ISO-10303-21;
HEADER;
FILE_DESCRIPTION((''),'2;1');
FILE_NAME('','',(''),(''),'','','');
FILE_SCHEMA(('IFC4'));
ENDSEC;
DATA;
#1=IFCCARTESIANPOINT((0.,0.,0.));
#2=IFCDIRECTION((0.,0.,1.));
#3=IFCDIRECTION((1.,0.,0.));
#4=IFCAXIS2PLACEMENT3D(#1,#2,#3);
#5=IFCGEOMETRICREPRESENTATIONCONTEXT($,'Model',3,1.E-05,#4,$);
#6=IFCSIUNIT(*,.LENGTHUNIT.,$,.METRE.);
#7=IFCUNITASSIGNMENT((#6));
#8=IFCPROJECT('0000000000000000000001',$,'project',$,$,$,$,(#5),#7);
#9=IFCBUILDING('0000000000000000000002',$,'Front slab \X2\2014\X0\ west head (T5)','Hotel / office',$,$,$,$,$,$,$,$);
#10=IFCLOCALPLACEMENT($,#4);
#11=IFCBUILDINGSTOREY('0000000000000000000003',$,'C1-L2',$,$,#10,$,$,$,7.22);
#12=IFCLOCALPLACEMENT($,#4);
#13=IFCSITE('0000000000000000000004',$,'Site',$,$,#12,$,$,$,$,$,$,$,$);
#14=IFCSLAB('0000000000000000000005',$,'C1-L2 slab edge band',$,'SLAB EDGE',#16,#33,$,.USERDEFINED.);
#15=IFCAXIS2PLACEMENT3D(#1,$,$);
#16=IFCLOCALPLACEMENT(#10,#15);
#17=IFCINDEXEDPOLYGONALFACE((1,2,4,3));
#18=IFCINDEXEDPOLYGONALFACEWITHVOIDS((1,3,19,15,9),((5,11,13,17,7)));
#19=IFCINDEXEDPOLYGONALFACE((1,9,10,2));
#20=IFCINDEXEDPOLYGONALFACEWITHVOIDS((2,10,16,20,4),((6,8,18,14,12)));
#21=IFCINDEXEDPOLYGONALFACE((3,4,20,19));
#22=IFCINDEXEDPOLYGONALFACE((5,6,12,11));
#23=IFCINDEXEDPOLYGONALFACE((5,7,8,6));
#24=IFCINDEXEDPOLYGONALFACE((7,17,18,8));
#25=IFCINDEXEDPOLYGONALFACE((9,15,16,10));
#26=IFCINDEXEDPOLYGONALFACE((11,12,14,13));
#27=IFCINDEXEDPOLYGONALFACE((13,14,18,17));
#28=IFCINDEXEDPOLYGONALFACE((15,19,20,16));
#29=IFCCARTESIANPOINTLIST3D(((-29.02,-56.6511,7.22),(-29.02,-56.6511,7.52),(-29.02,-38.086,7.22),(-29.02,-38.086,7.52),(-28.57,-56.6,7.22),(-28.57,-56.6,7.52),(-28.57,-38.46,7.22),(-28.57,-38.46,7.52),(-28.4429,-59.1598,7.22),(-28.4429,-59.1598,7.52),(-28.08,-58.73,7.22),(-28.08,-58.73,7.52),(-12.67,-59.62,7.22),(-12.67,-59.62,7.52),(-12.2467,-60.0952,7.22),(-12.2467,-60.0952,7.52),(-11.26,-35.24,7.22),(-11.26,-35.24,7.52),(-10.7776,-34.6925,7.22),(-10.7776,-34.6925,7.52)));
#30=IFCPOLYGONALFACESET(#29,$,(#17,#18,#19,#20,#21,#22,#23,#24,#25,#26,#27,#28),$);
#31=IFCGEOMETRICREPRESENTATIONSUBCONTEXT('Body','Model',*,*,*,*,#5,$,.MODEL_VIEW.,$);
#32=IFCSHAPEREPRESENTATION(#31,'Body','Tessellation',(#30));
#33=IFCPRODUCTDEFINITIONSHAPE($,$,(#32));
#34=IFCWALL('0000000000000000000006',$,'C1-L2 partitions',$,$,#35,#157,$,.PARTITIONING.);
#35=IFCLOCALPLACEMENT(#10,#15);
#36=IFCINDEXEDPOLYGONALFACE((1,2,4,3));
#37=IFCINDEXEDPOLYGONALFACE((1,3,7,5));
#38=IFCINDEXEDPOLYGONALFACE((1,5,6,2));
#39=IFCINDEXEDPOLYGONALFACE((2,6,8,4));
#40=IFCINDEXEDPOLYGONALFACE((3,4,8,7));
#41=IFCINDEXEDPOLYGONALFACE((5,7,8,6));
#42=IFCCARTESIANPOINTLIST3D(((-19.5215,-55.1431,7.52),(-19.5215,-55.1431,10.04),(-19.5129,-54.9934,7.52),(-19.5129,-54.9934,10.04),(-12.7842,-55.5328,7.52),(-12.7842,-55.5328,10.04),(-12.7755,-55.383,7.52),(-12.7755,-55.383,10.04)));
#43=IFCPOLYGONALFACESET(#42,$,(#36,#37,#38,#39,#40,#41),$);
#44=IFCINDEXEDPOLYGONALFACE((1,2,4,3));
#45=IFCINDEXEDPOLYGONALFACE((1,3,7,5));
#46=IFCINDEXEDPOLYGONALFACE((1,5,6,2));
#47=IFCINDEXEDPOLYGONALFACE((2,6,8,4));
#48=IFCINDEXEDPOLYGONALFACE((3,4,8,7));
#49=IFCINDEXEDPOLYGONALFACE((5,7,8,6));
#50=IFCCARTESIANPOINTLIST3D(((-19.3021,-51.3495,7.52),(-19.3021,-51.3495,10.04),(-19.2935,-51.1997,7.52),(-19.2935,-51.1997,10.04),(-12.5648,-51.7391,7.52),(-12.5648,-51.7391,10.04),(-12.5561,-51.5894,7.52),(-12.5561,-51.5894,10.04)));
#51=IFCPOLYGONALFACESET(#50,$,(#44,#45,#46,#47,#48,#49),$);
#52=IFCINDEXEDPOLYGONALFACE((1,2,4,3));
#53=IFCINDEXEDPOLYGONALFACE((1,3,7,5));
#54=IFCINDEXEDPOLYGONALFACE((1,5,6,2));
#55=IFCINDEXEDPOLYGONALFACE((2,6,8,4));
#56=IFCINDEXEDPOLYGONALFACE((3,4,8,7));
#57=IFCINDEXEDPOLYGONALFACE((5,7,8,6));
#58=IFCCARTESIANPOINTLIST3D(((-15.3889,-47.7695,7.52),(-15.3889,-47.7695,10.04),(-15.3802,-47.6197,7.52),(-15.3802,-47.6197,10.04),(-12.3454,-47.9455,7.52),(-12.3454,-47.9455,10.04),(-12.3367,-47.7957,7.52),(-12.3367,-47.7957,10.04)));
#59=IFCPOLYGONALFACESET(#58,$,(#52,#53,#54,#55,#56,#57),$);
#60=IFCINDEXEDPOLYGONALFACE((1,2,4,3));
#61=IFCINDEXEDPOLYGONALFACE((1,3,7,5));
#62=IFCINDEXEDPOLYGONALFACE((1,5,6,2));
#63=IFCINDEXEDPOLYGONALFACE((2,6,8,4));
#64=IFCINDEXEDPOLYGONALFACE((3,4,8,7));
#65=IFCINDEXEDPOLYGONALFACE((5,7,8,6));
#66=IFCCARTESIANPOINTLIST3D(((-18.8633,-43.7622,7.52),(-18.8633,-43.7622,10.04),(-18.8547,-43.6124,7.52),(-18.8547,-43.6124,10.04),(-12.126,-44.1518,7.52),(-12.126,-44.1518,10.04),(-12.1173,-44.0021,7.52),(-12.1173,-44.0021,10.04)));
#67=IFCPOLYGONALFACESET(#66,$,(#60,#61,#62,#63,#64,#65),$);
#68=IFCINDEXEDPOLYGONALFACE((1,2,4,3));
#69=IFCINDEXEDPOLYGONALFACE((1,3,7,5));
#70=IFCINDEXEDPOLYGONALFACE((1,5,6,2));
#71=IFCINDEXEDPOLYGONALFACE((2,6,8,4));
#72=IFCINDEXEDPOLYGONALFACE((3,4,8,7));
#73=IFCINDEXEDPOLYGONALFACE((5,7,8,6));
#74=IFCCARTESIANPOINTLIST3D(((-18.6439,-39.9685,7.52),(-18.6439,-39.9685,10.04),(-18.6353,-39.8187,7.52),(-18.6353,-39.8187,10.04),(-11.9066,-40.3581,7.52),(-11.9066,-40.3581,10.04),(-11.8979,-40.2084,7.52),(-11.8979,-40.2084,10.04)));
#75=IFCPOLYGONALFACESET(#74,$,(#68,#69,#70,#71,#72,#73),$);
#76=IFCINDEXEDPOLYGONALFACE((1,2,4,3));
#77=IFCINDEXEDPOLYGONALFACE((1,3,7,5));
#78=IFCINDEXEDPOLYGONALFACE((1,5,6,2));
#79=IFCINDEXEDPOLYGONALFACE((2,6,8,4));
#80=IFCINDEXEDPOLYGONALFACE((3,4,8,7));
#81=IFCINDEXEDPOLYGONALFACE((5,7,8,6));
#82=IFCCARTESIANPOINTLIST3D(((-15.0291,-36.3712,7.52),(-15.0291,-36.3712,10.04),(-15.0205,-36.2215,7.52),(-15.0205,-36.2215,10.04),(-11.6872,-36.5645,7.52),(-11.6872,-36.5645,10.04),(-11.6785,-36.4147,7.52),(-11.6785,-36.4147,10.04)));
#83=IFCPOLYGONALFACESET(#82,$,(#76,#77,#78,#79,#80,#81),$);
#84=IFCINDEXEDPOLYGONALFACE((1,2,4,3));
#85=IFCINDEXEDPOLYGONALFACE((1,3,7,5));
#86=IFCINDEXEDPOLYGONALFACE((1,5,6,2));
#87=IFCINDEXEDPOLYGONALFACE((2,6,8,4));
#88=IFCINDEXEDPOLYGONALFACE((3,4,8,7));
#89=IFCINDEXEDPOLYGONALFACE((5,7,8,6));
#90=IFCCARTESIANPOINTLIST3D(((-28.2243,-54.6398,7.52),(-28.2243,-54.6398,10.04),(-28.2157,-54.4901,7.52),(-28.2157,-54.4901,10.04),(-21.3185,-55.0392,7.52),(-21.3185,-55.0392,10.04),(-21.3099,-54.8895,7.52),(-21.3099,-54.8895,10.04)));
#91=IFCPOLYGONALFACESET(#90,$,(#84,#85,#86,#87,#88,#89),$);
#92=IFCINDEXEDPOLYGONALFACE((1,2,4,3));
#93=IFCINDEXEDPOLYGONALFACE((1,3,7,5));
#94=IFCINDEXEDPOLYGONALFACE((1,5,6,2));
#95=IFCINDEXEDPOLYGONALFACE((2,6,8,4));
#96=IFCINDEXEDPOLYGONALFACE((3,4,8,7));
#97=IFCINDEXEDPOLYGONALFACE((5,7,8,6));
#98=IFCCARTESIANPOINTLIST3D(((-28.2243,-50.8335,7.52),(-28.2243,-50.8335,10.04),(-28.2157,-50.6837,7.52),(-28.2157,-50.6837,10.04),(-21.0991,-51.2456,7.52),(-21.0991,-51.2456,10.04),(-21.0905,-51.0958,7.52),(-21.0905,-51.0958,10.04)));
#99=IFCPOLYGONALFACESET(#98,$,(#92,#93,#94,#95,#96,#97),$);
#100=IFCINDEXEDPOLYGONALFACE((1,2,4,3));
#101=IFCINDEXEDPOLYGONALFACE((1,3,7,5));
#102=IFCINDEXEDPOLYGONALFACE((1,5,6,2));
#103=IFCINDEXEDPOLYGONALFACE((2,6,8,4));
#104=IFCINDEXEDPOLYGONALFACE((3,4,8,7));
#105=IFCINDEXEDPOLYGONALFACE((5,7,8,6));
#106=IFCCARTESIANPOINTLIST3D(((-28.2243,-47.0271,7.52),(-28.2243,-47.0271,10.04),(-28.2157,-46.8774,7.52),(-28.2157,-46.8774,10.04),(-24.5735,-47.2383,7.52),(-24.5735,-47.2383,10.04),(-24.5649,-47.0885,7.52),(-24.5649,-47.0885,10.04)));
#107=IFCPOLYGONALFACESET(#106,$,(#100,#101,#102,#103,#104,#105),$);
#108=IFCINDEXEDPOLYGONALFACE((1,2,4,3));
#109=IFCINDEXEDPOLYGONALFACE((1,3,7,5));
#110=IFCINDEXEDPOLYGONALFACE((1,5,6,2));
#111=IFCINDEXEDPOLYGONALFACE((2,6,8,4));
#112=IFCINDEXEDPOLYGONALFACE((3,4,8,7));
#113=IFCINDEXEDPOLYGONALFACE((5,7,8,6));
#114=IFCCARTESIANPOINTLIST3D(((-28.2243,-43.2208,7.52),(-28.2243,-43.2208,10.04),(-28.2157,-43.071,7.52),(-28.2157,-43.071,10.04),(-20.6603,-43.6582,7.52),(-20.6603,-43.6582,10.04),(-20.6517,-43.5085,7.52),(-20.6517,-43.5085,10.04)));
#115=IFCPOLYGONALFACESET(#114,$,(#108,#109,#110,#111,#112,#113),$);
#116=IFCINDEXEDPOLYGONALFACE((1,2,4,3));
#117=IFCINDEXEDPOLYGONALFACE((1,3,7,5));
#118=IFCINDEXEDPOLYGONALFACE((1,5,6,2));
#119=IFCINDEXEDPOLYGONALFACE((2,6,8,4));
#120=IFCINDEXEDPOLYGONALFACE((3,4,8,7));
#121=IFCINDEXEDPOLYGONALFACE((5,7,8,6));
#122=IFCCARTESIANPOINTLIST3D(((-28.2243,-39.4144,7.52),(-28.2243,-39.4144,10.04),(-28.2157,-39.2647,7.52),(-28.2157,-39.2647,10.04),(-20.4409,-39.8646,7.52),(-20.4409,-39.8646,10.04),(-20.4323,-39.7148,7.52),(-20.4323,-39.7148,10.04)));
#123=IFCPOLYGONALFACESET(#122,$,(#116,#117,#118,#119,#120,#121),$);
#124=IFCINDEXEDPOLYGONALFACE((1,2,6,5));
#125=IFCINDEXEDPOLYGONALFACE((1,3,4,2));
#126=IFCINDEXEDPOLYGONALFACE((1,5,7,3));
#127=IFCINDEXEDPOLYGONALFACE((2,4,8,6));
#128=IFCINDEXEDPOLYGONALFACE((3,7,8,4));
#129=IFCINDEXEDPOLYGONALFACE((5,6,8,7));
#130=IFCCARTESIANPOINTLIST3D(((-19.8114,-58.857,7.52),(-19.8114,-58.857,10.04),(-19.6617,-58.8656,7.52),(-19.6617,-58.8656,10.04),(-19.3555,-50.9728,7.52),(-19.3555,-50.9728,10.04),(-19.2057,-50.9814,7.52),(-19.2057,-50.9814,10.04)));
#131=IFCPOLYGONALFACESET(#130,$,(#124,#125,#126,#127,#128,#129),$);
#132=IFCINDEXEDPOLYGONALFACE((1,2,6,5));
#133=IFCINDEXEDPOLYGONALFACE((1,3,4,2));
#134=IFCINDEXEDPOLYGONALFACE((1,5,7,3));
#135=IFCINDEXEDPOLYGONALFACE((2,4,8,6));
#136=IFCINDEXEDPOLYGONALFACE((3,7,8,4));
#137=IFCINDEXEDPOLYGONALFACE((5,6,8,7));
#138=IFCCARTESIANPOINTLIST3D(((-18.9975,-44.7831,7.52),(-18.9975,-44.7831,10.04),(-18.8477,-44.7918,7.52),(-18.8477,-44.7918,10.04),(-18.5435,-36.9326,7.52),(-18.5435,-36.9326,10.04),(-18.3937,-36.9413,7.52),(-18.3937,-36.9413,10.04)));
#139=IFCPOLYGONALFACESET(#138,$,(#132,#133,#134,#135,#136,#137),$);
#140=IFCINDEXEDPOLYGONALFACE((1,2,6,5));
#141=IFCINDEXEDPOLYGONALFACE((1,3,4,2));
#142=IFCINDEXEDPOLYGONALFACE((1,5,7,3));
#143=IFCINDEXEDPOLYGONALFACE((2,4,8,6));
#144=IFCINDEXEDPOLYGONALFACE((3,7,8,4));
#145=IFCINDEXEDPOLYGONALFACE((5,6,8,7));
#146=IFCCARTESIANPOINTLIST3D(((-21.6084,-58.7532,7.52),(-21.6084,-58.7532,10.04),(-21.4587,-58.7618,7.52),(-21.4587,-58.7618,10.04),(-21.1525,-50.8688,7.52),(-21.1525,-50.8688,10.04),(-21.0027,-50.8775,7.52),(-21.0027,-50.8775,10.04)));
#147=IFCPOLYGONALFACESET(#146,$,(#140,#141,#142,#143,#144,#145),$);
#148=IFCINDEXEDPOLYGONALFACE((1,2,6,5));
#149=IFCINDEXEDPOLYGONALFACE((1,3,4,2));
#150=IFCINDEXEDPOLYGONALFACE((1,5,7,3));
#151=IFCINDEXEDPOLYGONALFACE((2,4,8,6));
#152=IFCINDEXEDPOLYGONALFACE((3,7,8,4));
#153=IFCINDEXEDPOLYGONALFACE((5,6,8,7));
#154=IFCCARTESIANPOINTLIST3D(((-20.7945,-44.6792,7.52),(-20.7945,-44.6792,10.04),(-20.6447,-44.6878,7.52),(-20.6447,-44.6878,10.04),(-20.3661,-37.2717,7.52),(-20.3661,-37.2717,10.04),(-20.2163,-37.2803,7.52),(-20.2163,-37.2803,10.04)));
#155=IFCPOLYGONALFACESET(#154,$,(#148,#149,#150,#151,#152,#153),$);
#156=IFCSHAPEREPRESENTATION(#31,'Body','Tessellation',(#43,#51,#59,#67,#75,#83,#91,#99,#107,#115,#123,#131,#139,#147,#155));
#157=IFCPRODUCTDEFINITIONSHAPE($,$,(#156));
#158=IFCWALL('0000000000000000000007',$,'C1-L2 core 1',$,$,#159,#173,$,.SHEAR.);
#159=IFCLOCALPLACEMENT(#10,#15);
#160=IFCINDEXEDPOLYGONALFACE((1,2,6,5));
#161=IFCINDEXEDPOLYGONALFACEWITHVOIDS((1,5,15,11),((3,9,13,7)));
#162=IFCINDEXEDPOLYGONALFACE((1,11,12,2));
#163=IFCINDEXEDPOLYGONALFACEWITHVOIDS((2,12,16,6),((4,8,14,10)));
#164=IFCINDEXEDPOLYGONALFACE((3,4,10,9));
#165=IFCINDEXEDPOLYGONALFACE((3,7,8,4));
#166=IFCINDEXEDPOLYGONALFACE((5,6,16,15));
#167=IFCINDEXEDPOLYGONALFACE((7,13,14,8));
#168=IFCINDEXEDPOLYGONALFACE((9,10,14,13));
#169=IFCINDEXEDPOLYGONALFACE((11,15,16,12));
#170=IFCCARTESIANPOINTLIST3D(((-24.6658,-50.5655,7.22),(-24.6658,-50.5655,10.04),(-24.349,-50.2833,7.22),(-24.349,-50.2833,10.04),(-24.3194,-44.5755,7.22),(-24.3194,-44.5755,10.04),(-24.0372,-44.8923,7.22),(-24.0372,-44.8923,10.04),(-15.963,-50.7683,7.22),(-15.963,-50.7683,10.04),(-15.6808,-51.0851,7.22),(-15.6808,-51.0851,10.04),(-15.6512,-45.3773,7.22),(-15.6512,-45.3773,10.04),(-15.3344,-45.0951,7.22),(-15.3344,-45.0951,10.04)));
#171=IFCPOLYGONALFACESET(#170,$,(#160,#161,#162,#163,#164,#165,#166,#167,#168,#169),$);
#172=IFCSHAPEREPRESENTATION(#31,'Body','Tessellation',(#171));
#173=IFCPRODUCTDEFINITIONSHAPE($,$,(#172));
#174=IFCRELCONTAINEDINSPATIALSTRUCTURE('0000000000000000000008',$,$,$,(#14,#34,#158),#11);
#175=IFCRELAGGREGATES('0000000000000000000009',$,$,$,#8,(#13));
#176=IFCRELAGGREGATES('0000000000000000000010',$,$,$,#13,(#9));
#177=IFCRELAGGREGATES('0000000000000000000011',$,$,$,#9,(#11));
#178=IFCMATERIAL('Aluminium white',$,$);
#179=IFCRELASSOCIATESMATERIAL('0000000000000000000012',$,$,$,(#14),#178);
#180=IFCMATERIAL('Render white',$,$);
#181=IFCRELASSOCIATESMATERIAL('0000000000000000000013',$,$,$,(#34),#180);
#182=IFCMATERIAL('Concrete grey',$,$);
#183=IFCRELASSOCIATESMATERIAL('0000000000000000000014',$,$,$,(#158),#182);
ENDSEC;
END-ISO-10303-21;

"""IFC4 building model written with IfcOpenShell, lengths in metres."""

from ifc_helpers import new_model, si_unit, frame, origin_with_axes, place, context, subcontext, project, spatial, polyline, outline, extrude, material, element, save


model = new_model("IFC4")

# Units and contexts
model_context = context("Model", 3, precision=1e-05, world=origin_with_axes())
body_context = subcontext(model_context, "Body", "Model", "MODEL_VIEW")
ifc_project = project(units=[si_unit("LENGTHUNIT", "METRE")], contexts=[model_context])

# Site, building, storey
site_placement = place(None, origin_with_axes())
site = spatial("IfcSite", under=ifc_project, at=site_placement, Name="Site")
building = spatial("IfcBuilding", under=site, Name="Front slab — west head (T5)", Description="Hotel / office")
storey_placement = place(None, origin_with_axes())
storey = spatial("IfcBuildingStorey", under=building, at=storey_placement, Name="C1-L2", Elevation=7.22)

# Shared definitions
ifc_material_1 = material(Name="Aluminium white")

# Slab
slab_placement = place(storey_placement, origin_with_axes())
element("IfcSlab", 1, at=slab_placement, inside=storey, material=ifc_material_1, Name="C1-L2 slab edge band", ObjectType="SLAB EDGE", PredefinedType="USERDEFINED", context=body_context, shape_type="SweptSolid", body=[
    extrude(outline(polyline([(-10.7776, -34.6925), (-29.02, -38.086), (-29.02, -56.6511), (-28.4429, -59.1598), (-12.2467, -60.0952), (-10.7776, -34.6925)]), holes=[polyline([(-11.26, -35.24), (-28.57, -38.46), (-28.57, -56.6), (-28.08, -58.73), (-12.67, -59.62), (-11.26, -35.24)])]), frame((0.0, 0.0, 7.22), z_axis=(0.0, 0.0, 1.0), x_axis=(1.0, 0.0, 0.0)), (0.0, 0.0, 1.0), 0.3),
])

# Walls
ifc_material_2 = material(Name="Render white")
wall_1_placement = place(storey_placement, origin_with_axes())
element("IfcWall", 2, at=wall_1_placement, inside=storey, material=ifc_material_2, Name="C1-L2 partitions", PredefinedType="PARTITIONING", context=body_context, shape_type="SweptSolid", body=[
    extrude(outline(polyline([(-12.7755, -55.383), (-19.5129, -54.9934), (-19.5215, -55.1431), (-12.7842, -55.5328), (-12.7755, -55.383)])), frame((0.0, 0.0, 7.52), z_axis=(0.0, 0.0, 1.0), x_axis=(1.0, 0.0, 0.0)), (0.0, 0.0, 1.0), 2.52),
    extrude(outline(polyline([(-12.5561, -51.5894), (-19.2935, -51.1997), (-19.3021, -51.3495), (-12.5648, -51.7391), (-12.5561, -51.5894)])), frame((0.0, 0.0, 7.52), z_axis=(0.0, 0.0, 1.0), x_axis=(1.0, 0.0, 0.0)), (0.0, 0.0, 1.0), 2.52),
    extrude(outline(polyline([(-12.3367, -47.7957), (-15.3802, -47.6197), (-15.3889, -47.7695), (-12.3454, -47.9455), (-12.3367, -47.7957)])), frame((0.0, 0.0, 7.52), z_axis=(0.0, 0.0, 1.0), x_axis=(1.0, 0.0, 0.0)), (0.0, 0.0, 1.0), 2.52),
    extrude(outline(polyline([(-12.1173, -44.0021), (-18.8547, -43.6124), (-18.8633, -43.7622), (-12.126, -44.1518), (-12.1173, -44.0021)])), frame((0.0, 0.0, 7.52), z_axis=(0.0, 0.0, 1.0), x_axis=(1.0, 0.0, 0.0)), (0.0, 0.0, 1.0), 2.52),
    extrude(outline(polyline([(-11.8979, -40.2084), (-18.6353, -39.8187), (-18.6439, -39.9685), (-11.9066, -40.3581), (-11.8979, -40.2084)])), frame((0.0, 0.0, 7.52), z_axis=(0.0, 0.0, 1.0), x_axis=(1.0, 0.0, 0.0)), (0.0, 0.0, 1.0), 2.52),
    extrude(outline(polyline([(-11.6785, -36.4147), (-15.0205, -36.2215), (-15.0291, -36.3712), (-11.6872, -36.5645), (-11.6785, -36.4147)])), frame((0.0, 0.0, 7.52), z_axis=(0.0, 0.0, 1.0), x_axis=(1.0, 0.0, 0.0)), (0.0, 0.0, 1.0), 2.52),
    extrude(outline(polyline([(-21.3099, -54.8895), (-28.2157, -54.4901), (-28.2243, -54.6398), (-21.3185, -55.0392), (-21.3099, -54.8895)])), frame((0.0, 0.0, 7.52), z_axis=(0.0, 0.0, 1.0), x_axis=(1.0, 0.0, 0.0)), (0.0, 0.0, 1.0), 2.52),
    extrude(outline(polyline([(-21.0905, -51.0958), (-28.2157, -50.6837), (-28.2243, -50.8335), (-21.0991, -51.2456), (-21.0905, -51.0958)])), frame((0.0, 0.0, 7.52), z_axis=(0.0, 0.0, 1.0), x_axis=(1.0, 0.0, 0.0)), (0.0, 0.0, 1.0), 2.52),
    extrude(outline(polyline([(-24.5649, -47.0885), (-28.2157, -46.8774), (-28.2243, -47.0271), (-24.5735, -47.2383), (-24.5649, -47.0885)])), frame((0.0, 0.0, 7.52), z_axis=(0.0, 0.0, 1.0), x_axis=(1.0, 0.0, 0.0)), (0.0, 0.0, 1.0), 2.52),
    extrude(outline(polyline([(-20.6517, -43.5085), (-28.2157, -43.071), (-28.2243, -43.2208), (-20.6603, -43.6582), (-20.6517, -43.5085)])), frame((0.0, 0.0, 7.52), z_axis=(0.0, 0.0, 1.0), x_axis=(1.0, 0.0, 0.0)), (0.0, 0.0, 1.0), 2.52),
    extrude(outline(polyline([(-20.4323, -39.7148), (-28.2157, -39.2647), (-28.2243, -39.4144), (-20.4409, -39.8646), (-20.4323, -39.7148)])), frame((0.0, 0.0, 7.52), z_axis=(0.0, 0.0, 1.0), x_axis=(1.0, 0.0, 0.0)), (0.0, 0.0, 1.0), 2.52),
    extrude(outline(polyline([(-19.6617, -58.8656), (-19.2057, -50.9814), (-19.3555, -50.9728), (-19.8114, -58.857), (-19.6617, -58.8656)])), frame((0.0, 0.0, 7.52), z_axis=(0.0, 0.0, 1.0), x_axis=(1.0, 0.0, 0.0)), (0.0, 0.0, 1.0), 2.52),
    extrude(outline(polyline([(-18.8477, -44.7918), (-18.3937, -36.9413), (-18.5435, -36.9326), (-18.9975, -44.7831), (-18.8477, -44.7918)])), frame((0.0, 0.0, 7.52), z_axis=(0.0, 0.0, 1.0), x_axis=(1.0, 0.0, 0.0)), (0.0, 0.0, 1.0), 2.52),
    extrude(outline(polyline([(-21.4587, -58.7618), (-21.0027, -50.8775), (-21.1525, -50.8688), (-21.6084, -58.7532), (-21.4587, -58.7618)])), frame((0.0, 0.0, 7.52), z_axis=(0.0, 0.0, 1.0), x_axis=(1.0, 0.0, 0.0)), (0.0, 0.0, 1.0), 2.52),
    extrude(outline(polyline([(-20.6447, -44.6878), (-20.2163, -37.2803), (-20.3661, -37.2717), (-20.7945, -44.6792), (-20.6447, -44.6878)])), frame((0.0, 0.0, 7.52), z_axis=(0.0, 0.0, 1.0), x_axis=(1.0, 0.0, 0.0)), (0.0, 0.0, 1.0), 2.52),
])
ifc_material_3 = material(Name="Concrete grey")
wall_2_placement = place(storey_placement, origin_with_axes())
element("IfcWall", 3, at=wall_2_placement, inside=storey, material=ifc_material_3, Name="C1-L2 core 1", PredefinedType="SHEAR", context=body_context, shape_type="SweptSolid", body=[
    extrude(outline(polyline([(-15.6808, -51.0851), (-15.3344, -45.0951), (-24.3194, -44.5755), (-24.6658, -50.5655), (-15.6808, -51.0851)]), holes=[polyline([(-15.963, -50.7683), (-15.6512, -45.3773), (-24.0372, -44.8923), (-24.349, -50.2833), (-15.963, -50.7683)])]), frame((0.0, 0.0, 7.22), z_axis=(0.0, 0.0, 1.0), x_axis=(1.0, 0.0, 0.0)), (0.0, 0.0, 1.0), 2.82),
])

save(model, "model.ifc")
